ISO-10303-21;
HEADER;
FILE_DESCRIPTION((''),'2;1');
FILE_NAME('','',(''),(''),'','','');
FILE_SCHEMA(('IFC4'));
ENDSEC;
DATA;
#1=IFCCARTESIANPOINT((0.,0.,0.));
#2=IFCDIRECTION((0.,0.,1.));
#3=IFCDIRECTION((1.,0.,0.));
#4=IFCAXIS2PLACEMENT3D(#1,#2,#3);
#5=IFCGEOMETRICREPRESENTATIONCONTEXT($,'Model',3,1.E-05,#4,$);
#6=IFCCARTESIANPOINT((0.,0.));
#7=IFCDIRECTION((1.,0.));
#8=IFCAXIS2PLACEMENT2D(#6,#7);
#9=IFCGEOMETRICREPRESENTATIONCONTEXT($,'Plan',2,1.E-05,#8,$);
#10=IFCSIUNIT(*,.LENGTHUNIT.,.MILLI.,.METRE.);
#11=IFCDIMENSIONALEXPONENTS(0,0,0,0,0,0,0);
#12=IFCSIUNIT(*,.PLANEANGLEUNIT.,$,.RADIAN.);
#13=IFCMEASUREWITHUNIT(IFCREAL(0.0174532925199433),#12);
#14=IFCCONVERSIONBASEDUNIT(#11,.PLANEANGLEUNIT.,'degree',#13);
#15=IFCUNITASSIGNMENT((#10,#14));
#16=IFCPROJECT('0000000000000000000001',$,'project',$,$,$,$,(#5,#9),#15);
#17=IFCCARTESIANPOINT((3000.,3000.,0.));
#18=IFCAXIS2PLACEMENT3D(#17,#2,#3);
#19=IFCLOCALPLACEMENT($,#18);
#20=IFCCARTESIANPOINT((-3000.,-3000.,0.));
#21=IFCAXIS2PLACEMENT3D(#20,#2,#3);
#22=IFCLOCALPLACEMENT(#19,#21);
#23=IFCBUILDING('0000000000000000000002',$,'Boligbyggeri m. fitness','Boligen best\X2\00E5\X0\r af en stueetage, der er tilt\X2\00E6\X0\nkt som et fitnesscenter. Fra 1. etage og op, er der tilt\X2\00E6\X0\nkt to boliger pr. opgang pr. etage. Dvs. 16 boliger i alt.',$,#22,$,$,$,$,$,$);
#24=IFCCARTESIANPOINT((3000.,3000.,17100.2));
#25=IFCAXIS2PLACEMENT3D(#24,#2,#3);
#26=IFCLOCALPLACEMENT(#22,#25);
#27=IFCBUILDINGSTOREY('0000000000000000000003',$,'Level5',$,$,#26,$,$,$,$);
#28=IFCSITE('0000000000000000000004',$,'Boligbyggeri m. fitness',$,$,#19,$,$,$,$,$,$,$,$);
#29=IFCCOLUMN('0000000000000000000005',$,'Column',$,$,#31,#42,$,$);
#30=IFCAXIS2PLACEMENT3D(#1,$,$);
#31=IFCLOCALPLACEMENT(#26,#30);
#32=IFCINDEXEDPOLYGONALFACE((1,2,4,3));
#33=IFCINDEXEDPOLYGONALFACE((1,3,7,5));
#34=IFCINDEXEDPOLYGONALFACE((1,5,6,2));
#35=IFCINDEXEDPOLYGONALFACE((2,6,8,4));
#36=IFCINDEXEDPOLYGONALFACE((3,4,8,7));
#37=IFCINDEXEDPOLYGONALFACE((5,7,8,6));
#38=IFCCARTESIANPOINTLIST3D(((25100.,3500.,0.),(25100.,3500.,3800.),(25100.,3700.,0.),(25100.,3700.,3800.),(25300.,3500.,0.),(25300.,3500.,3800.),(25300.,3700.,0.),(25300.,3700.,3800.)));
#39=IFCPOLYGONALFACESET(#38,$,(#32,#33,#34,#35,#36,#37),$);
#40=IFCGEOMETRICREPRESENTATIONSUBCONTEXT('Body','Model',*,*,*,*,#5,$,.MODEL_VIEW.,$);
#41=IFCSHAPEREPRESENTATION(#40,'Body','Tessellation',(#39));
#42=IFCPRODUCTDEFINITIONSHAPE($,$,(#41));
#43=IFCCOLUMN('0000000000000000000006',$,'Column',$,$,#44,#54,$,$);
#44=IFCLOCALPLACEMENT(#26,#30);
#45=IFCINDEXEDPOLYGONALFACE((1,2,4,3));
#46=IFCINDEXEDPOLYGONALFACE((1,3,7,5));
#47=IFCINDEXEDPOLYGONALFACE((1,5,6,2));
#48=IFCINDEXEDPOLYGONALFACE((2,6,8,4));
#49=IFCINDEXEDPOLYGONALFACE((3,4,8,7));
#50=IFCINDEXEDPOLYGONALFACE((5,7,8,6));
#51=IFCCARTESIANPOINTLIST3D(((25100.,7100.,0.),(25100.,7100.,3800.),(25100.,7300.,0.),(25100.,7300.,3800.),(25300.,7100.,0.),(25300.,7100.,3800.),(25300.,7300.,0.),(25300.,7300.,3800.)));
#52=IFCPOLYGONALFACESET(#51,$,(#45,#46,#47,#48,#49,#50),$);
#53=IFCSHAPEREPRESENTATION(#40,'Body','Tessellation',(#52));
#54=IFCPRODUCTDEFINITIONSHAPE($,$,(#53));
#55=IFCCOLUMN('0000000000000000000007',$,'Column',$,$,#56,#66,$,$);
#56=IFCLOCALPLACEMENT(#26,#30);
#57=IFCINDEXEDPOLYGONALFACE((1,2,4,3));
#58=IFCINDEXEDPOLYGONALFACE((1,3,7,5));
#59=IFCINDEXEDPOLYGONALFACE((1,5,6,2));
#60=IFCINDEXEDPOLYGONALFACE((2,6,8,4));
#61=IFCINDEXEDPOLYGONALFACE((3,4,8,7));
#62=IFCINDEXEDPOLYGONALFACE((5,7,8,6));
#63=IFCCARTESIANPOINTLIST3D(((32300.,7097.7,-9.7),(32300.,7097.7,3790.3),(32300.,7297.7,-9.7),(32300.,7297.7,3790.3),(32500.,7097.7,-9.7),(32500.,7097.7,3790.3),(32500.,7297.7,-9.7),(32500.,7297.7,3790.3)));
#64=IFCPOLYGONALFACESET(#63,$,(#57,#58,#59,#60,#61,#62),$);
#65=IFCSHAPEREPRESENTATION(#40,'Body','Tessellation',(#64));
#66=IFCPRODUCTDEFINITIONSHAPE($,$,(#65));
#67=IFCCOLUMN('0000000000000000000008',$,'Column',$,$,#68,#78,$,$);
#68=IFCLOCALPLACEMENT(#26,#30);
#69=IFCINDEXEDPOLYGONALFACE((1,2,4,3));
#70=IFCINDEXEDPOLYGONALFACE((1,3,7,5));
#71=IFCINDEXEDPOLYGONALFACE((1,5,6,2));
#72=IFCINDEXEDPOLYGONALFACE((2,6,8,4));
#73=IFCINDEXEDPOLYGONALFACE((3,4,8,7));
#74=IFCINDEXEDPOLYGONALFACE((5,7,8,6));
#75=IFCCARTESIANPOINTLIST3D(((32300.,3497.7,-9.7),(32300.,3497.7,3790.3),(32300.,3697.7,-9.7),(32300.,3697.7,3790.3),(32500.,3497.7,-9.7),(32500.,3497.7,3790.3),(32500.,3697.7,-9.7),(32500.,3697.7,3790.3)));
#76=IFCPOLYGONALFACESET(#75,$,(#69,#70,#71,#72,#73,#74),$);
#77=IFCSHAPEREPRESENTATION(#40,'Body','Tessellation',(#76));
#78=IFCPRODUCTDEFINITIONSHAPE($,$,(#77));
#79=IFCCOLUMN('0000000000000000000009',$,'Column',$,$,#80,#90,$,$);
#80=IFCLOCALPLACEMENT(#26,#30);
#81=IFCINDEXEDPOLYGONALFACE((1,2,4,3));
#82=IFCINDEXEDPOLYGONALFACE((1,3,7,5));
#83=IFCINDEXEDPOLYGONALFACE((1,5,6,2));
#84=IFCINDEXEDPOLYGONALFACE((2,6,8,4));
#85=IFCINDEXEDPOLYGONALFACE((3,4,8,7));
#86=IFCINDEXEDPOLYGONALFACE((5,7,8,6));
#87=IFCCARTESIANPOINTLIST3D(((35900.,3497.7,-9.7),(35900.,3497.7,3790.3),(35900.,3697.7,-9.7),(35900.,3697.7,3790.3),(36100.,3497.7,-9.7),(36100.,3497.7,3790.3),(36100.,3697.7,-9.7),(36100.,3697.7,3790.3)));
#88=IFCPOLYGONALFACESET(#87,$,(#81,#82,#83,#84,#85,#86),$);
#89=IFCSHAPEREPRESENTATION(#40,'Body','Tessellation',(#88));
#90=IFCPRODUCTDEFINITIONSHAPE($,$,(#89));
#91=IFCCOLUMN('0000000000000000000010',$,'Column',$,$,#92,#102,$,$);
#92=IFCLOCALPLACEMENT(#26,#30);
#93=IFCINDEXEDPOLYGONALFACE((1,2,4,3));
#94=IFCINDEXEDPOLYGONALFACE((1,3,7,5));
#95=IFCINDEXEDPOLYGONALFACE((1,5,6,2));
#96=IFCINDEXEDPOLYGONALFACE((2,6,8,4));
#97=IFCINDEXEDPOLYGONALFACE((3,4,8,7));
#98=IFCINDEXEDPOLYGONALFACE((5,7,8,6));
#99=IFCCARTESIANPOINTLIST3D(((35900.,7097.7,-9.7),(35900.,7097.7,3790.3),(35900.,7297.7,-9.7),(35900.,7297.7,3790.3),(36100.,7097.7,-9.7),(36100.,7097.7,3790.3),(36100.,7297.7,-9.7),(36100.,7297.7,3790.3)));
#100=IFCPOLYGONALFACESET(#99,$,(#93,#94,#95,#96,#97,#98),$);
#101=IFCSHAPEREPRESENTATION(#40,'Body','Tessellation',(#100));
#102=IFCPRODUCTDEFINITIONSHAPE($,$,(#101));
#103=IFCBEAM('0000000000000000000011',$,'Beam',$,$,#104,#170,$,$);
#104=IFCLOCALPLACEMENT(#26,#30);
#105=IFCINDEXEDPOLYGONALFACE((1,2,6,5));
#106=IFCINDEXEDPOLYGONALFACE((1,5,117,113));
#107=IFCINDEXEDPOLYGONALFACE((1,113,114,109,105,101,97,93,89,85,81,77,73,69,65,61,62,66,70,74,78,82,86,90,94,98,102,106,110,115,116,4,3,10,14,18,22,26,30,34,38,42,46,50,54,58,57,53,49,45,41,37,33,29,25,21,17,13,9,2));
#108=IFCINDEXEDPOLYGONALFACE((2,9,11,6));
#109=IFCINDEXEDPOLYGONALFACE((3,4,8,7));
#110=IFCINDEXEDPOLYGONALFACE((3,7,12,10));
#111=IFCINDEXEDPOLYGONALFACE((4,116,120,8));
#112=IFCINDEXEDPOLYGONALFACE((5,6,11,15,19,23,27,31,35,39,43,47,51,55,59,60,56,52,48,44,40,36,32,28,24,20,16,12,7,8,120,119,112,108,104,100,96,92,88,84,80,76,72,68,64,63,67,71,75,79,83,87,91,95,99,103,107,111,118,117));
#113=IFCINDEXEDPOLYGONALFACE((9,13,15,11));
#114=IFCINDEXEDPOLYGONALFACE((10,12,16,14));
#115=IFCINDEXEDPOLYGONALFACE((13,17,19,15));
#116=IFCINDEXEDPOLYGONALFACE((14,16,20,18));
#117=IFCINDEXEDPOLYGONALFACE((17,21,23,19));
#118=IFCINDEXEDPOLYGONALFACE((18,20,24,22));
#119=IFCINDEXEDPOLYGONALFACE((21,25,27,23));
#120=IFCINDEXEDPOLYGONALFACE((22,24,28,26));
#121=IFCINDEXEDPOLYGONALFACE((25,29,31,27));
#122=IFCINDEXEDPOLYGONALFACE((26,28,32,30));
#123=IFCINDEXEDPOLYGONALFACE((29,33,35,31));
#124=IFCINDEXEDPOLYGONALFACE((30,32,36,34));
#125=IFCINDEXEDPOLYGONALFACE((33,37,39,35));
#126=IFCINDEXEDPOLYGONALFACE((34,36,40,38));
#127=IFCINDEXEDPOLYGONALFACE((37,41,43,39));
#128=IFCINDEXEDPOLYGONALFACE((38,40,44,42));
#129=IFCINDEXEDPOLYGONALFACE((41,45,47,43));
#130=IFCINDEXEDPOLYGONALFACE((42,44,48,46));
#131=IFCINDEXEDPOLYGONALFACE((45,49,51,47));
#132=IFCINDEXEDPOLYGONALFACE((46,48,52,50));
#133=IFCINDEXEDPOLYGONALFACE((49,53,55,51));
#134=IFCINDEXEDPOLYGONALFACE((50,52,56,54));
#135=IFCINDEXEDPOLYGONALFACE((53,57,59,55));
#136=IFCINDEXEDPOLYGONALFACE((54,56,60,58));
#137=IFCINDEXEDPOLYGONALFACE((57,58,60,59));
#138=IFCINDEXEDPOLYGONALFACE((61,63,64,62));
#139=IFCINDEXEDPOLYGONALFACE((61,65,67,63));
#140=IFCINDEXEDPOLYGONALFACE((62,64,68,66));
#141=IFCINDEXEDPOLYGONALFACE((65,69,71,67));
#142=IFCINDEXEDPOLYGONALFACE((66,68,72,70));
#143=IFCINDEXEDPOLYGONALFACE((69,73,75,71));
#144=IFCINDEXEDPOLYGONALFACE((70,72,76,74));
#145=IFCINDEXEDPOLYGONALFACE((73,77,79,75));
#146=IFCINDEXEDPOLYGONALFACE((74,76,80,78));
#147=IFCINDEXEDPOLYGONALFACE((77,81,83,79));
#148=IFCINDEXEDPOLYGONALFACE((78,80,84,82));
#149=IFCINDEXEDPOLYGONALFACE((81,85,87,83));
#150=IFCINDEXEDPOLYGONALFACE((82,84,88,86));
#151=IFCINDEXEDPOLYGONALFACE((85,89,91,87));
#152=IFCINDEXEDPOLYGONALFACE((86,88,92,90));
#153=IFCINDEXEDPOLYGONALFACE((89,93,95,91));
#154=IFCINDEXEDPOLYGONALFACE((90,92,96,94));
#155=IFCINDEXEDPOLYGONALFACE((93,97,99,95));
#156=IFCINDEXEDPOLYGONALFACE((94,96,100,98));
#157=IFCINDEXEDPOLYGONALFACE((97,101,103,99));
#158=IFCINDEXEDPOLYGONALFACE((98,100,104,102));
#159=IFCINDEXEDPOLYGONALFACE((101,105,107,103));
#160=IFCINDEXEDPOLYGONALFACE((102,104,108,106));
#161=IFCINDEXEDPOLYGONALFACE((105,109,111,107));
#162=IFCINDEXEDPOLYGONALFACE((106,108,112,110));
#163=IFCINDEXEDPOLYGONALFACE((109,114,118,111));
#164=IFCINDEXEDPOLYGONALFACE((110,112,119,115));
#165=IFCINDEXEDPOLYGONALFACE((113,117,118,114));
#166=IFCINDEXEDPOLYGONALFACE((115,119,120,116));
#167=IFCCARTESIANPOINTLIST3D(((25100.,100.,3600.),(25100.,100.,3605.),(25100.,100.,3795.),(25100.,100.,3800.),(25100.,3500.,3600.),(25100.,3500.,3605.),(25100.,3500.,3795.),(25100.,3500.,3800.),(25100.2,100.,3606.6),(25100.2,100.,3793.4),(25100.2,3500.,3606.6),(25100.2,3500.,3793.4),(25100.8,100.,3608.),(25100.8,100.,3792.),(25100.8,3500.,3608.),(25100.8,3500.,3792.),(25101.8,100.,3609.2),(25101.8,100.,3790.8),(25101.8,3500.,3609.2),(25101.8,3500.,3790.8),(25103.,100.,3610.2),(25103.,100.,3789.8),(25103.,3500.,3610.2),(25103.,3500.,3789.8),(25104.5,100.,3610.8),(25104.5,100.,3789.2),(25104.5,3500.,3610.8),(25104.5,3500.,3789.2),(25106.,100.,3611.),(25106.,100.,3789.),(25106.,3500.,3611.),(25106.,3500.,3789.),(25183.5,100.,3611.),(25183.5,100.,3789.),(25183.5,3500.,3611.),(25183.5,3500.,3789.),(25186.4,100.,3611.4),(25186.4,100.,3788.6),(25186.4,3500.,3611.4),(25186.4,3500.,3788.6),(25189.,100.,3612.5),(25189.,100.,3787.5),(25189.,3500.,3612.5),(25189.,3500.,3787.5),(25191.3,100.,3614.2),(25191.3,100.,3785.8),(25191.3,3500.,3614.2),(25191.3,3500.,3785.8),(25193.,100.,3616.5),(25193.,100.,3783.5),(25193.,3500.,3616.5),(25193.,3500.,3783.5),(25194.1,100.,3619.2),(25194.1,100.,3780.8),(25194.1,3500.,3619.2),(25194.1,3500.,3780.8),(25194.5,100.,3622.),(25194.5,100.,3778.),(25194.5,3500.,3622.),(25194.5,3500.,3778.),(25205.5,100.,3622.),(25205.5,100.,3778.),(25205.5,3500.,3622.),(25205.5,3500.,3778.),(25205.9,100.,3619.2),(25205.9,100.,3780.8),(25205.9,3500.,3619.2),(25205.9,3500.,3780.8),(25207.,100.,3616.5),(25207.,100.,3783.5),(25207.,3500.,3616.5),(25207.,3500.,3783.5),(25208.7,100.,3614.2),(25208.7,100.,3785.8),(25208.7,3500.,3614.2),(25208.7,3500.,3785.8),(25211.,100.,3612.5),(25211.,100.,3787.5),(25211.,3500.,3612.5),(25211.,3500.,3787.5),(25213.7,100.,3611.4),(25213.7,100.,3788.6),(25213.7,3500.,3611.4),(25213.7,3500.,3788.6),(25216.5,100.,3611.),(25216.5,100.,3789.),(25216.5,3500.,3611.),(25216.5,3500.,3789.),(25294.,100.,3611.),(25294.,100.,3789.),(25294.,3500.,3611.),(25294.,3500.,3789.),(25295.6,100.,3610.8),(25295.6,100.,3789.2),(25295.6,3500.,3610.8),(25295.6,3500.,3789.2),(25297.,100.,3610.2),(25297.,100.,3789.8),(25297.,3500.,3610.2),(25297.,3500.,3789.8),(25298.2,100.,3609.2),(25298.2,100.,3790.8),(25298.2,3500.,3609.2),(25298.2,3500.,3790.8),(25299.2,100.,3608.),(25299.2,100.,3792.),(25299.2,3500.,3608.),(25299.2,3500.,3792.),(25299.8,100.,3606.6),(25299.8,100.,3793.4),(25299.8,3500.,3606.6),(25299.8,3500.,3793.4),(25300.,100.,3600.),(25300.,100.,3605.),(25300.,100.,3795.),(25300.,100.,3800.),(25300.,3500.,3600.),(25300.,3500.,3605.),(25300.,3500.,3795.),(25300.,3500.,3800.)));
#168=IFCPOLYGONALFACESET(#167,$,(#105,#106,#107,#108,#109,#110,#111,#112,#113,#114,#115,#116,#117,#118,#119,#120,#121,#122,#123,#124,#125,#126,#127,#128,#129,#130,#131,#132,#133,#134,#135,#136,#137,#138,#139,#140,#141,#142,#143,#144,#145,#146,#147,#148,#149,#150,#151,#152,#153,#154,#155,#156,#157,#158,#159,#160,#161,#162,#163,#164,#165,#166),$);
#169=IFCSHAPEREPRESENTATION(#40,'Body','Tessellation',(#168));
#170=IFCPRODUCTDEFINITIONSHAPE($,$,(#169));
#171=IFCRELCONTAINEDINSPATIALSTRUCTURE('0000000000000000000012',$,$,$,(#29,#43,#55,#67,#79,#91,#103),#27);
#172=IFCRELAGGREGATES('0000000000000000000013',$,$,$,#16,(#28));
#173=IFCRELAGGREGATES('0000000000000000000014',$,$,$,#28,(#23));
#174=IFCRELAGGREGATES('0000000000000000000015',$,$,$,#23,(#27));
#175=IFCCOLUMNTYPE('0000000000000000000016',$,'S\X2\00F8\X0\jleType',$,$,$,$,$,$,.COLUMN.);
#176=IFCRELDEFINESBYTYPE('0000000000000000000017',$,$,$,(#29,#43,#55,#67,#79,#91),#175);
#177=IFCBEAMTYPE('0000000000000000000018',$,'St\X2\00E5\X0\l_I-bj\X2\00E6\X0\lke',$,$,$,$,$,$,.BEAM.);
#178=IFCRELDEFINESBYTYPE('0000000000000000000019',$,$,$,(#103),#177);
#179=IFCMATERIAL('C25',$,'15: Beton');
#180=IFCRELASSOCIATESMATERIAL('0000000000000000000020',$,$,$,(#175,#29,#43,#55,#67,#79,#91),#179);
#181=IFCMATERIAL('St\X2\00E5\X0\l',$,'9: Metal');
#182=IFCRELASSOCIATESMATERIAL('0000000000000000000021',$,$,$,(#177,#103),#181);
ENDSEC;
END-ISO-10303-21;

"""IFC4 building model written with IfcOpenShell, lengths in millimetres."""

from ifc_helpers import new_model, entity, si_unit, converted_unit, frame, origin_with_axes, origin_2d_with_axis, place, context, subcontext, project, spatial, rectangle, i_section, extrude, material, material_profile, profile_set, profile_usage, type_object, element, save


model = new_model("IFC4")

# Units and contexts
model_context = context("Model", 3, precision=1e-05, world=origin_with_axes())
plan_context = context("Plan", 2, precision=1e-05, world=origin_2d_with_axis())
body_context = subcontext(model_context, "Body", "Model", "MODEL_VIEW")
ifc_project = project(units=[si_unit("LENGTHUNIT", "METRE", prefix="MILLI"), converted_unit("PLANEANGLEUNIT", "degree", entity("IfcReal", 0.0174532925199433), si_unit("PLANEANGLEUNIT", "RADIAN"), dimensions=[0, 0, 0, 0, 0, 0, 0])], contexts=[model_context, plan_context])

# Site, building, storey
site_placement = place(None, frame((3000.0, 3000.0, 0.0), z_axis=(0.0, 0.0, 1.0), x_axis=(1.0, 0.0, 0.0)))
site = spatial("IfcSite", under=ifc_project, at=site_placement, Name="Boligbyggeri m. fitness")
building_placement = place(site_placement, frame((-3000.0, -3000.0, 0.0), z_axis=(0.0, 0.0, 1.0), x_axis=(1.0, 0.0, 0.0)))
building = spatial("IfcBuilding", under=site, at=building_placement, Name="Boligbyggeri m. fitness", Description="Boligen består af en stueetage, der er tiltænkt som et fitnesscenter. Fra 1. etage og op, er der tiltænkt to boliger pr. opgang pr. etage. Dvs. 16 boliger i alt.")
storey_placement = place(building_placement, frame((3000.0, 3000.0, 17100.2), z_axis=(0.0, 0.0, 1.0), x_axis=(1.0, 0.0, 0.0)))
storey = spatial("IfcBuildingStorey", under=building, at=storey_placement, Name="Level5")

# Columns
ifc_material_1 = material(Name="C25", Category="15: Beton")
ifc_material_profile_1 = material_profile(ifc_material_1, rectangle(XDim=200.0, YDim=200.0), Name="SøjleBeton", Category="15: Beton")
ifc_profile_set_1 = profile_set([ifc_material_profile_1], Name="200x200")
ifc_profile_usage_1 = profile_usage(ifc_profile_set_1, cardinal=5)
column_type = type_object("IfcColumnType", Name="SøjleType", PredefinedType="COLUMN", material=ifc_profile_set_1)
column_1_placement = place(storey_placement, frame((25200.0, 3600.0, 0.0), z_axis=(0.0, 0.0, 1.0), x_axis=(1.0, 0.0, 0.0)))
element("IfcColumn", 1, at=column_1_placement, inside=storey, type_object=column_type, material=ifc_profile_usage_1, Name="Column", context=body_context, shape_type="SweptSolid", body=[
    extrude(rectangle(XDim=200.0, YDim=200.0), origin_with_axes(), (0.0, 0.0, 1.0), 3800.0),
])
ifc_profile_usage_2 = profile_usage(ifc_profile_set_1, cardinal=5)
column_2_placement = place(storey_placement, frame((25200.0, 7200.0, 0.0), z_axis=(0.0, 0.0, 1.0), x_axis=(1.0, 0.0, 0.0)))
element("IfcColumn", 2, at=column_2_placement, inside=storey, type_object=column_type, material=ifc_profile_usage_2, Name="Column", context=body_context, shape_type="SweptSolid", body=[
    extrude(rectangle(XDim=200.0, YDim=200.0), origin_with_axes(), (0.0, 0.0, 1.0), 3800.0),
])
ifc_profile_usage_3 = profile_usage(ifc_profile_set_1, cardinal=5)
column_3_placement = place(storey_placement, frame((32400.0, 7197.7, -9.7), z_axis=(0.0, 0.0, 1.0), x_axis=(1.0, 0.0, 0.0)))
element("IfcColumn", 3, at=column_3_placement, inside=storey, type_object=column_type, material=ifc_profile_usage_3, Name="Column", context=body_context, shape_type="SweptSolid", body=[
    extrude(rectangle(XDim=200.0, YDim=200.0), origin_with_axes(), (0.0, 0.0, 1.0), 3800.0),
])
ifc_profile_usage_4 = profile_usage(ifc_profile_set_1, cardinal=5)
column_4_placement = place(storey_placement, frame((32400.0, 3597.7, -9.7), z_axis=(0.0, 0.0, 1.0), x_axis=(1.0, 0.0, 0.0)))
element("IfcColumn", 4, at=column_4_placement, inside=storey, type_object=column_type, material=ifc_profile_usage_4, Name="Column", context=body_context, shape_type="SweptSolid", body=[
    extrude(rectangle(XDim=200.0, YDim=200.0), origin_with_axes(), (0.0, 0.0, 1.0), 3800.0),
])
ifc_profile_usage_5 = profile_usage(ifc_profile_set_1, cardinal=5)
column_5_placement = place(storey_placement, frame((36000.0, 3597.7, -9.7), z_axis=(0.0, 0.0, 1.0), x_axis=(1.0, 0.0, 0.0)))
element("IfcColumn", 5, at=column_5_placement, inside=storey, type_object=column_type, material=ifc_profile_usage_5, Name="Column", context=body_context, shape_type="SweptSolid", body=[
    extrude(rectangle(XDim=200.0, YDim=200.0), origin_with_axes(), (0.0, 0.0, 1.0), 3800.0),
])
ifc_profile_usage_6 = profile_usage(ifc_profile_set_1, cardinal=5)
column_6_placement = place(storey_placement, frame((36000.0, 7197.7, -9.7), z_axis=(0.0, 0.0, 1.0), x_axis=(1.0, 0.0, 0.0)))
element("IfcColumn", 6, at=column_6_placement, inside=storey, type_object=column_type, material=ifc_profile_usage_6, Name="Column", context=body_context, shape_type="SweptSolid", body=[
    extrude(rectangle(XDim=200.0, YDim=200.0), origin_with_axes(), (0.0, 0.0, 1.0), 3800.0),
])

# Beam
ifc_material_2 = material(Name="Stål", Category="9: Metal")
ifc_material_profile_2 = material_profile(ifc_material_2, i_section(OverallWidth=200.0, OverallDepth=200.0, WebThickness=11.0, FlangeThickness=11.0, FilletRadius=11.0, FlangeEdgeRadius=6.0), Name="Stål", Category="9: Metal")
ifc_profile_set_2 = profile_set([ifc_material_profile_2], Name="NY_I-Profil")
ifc_profile_usage_7 = profile_usage(ifc_profile_set_2, cardinal=9)
beam_type = type_object("IfcBeamType", Name="Stål_I-bjælke", PredefinedType="BEAM", material=ifc_profile_set_2)
beam_1_placement = place(storey_placement, frame((25300.0, 100.0, 3800.0), z_axis=(0.0, 1.0, 0.0), x_axis=(-1.0, 0.0, 0.0)))
element("IfcBeam", 7, at=beam_1_placement, inside=storey, type_object=beam_type, material=ifc_profile_usage_7, Name="Beam", context=body_context, shape_type="SweptSolid", body=[
    extrude(i_section(OverallWidth=200.0, OverallDepth=200.0, WebThickness=11.0, FlangeThickness=11.0, FilletRadius=11.0, FlangeEdgeRadius=6.0), frame((100.0, -100.0, 0.0), z_axis=(0.0, 0.0, 1.0), x_axis=(1.0, 0.0, 0.0)), (0.0, 0.0, 1.0), 3400.0),
])

save(model, "model.ifc")
